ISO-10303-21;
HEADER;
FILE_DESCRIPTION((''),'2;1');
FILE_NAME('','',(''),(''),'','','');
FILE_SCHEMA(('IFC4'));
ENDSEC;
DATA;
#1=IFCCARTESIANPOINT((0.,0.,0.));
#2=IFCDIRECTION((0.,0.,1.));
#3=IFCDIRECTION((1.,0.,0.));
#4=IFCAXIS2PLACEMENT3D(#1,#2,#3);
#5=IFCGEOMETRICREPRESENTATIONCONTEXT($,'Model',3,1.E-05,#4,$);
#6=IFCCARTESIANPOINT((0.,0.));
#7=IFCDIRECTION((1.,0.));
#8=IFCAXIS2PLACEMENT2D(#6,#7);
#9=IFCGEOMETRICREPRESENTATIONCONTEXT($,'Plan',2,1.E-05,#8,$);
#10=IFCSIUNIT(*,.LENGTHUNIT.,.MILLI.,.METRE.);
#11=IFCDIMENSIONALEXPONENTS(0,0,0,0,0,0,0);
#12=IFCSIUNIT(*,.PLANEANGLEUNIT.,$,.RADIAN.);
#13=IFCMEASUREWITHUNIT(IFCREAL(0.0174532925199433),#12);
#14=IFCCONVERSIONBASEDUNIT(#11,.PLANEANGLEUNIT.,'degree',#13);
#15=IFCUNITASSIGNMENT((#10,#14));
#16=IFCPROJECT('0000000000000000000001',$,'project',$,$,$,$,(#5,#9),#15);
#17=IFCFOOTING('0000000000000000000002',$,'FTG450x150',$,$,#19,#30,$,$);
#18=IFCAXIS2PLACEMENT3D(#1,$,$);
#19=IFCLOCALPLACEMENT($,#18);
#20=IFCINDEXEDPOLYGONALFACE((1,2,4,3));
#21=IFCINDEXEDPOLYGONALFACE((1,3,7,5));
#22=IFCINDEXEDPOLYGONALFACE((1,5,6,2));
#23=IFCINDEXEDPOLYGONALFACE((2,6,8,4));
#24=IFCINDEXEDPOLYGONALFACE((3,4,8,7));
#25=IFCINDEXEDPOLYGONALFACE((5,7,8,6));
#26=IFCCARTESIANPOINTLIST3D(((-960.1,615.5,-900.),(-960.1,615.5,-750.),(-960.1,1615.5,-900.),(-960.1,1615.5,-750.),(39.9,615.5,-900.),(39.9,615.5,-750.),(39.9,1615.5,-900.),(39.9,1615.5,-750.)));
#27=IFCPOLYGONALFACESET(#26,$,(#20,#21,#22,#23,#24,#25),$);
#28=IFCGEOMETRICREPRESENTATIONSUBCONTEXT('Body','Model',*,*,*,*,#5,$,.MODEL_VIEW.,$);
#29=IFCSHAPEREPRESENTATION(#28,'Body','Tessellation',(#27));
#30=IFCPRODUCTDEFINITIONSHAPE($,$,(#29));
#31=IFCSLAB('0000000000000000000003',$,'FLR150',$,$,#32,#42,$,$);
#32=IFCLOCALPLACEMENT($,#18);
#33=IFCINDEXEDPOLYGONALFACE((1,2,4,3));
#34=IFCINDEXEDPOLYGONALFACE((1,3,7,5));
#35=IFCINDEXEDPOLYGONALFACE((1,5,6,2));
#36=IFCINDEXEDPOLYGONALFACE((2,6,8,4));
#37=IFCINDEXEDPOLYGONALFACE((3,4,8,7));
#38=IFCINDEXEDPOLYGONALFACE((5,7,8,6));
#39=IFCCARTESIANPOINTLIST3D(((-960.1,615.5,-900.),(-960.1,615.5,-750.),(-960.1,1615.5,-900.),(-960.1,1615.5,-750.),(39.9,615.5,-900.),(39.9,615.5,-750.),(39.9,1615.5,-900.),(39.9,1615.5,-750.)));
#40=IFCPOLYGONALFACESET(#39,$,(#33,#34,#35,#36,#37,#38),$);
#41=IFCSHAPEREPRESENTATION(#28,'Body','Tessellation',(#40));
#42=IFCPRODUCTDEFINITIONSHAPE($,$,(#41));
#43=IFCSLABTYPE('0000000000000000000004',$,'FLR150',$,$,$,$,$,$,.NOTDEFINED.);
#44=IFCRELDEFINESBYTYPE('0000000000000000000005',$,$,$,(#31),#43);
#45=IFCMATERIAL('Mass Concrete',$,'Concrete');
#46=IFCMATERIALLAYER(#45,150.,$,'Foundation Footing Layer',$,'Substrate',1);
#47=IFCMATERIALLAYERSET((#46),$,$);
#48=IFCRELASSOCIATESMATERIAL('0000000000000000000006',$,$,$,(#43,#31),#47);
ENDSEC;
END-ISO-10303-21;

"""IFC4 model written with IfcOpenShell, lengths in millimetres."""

from ifc_helpers import new_model, entity, si_unit, converted_unit, frame, origin_with_axes, origin_2d_with_axis, place, context, subcontext, project, indexed_curve, outline, extrude, material, layer, layer_set, layer_usage, type_object, element, save


model = new_model("IFC4")

# Units and contexts
model_context = context("Model", 3, precision=1e-05, world=origin_with_axes())
plan_context = context("Plan", 2, precision=1e-05, world=origin_2d_with_axis())
body_context = subcontext(model_context, "Body", "Model", "MODEL_VIEW")
ifc_project = project(units=[si_unit("LENGTHUNIT", "METRE", prefix="MILLI"), converted_unit("PLANEANGLEUNIT", "degree", entity("IfcReal", 0.0174532925199433), si_unit("PLANEANGLEUNIT", "RADIAN"), dimensions=[0, 0, 0, 0, 0, 0, 0])], contexts=[model_context, plan_context])

# Footing
footing_placement = place(None, frame((-960.1, 615.5, -900.0), z_axis=(0.0, 0.0, 1.0), x_axis=(1.0, 0.0, 0.0)))
element("IfcFooting", 1, at=footing_placement, Name="FTG450x150", context=body_context, shape_type="SweptSolid", body=[
    extrude(outline(indexed_curve([(0.0, 0.0), (1000.0, 0.0), (1000.0, 1000.0), (0.0, 1000.0), (0.0, 0.0)])), None, (0.0, 0.0, 1.0), 150.0),
])

# Slab
ifc_material = material(Name="Mass Concrete", Category="Concrete")
ifc_layer = layer(ifc_material, 150.0, Name="Foundation Footing Layer", Category="Substrate", Priority=1)
ifc_layer_set = layer_set([ifc_layer])
ifc_layer_usage = layer_usage(ifc_layer_set, "AXIS3", "POSITIVE", 0.0)
slab_type = type_object("IfcSlabType", Name="FLR150", PredefinedType="NOTDEFINED", material=ifc_layer_set)
slab_placement = place(None, frame((-960.1, 615.5, -900.0), z_axis=(0.0, 0.0, 1.0), x_axis=(1.0, 0.0, 0.0)))
element("IfcSlab", 2, at=slab_placement, type_object=slab_type, material=ifc_layer_usage, Name="FLR150", context=body_context, shape_type="SweptSolid", body=[
    extrude(outline(indexed_curve([(0.0, 0.0), (1000.0, 0.0), (1000.0, 1000.0), (0.0, 1000.0), (0.0, 0.0)])), None, (0.0, 0.0, 1.0), 150.0),
])

save(model, "model.ifc")
